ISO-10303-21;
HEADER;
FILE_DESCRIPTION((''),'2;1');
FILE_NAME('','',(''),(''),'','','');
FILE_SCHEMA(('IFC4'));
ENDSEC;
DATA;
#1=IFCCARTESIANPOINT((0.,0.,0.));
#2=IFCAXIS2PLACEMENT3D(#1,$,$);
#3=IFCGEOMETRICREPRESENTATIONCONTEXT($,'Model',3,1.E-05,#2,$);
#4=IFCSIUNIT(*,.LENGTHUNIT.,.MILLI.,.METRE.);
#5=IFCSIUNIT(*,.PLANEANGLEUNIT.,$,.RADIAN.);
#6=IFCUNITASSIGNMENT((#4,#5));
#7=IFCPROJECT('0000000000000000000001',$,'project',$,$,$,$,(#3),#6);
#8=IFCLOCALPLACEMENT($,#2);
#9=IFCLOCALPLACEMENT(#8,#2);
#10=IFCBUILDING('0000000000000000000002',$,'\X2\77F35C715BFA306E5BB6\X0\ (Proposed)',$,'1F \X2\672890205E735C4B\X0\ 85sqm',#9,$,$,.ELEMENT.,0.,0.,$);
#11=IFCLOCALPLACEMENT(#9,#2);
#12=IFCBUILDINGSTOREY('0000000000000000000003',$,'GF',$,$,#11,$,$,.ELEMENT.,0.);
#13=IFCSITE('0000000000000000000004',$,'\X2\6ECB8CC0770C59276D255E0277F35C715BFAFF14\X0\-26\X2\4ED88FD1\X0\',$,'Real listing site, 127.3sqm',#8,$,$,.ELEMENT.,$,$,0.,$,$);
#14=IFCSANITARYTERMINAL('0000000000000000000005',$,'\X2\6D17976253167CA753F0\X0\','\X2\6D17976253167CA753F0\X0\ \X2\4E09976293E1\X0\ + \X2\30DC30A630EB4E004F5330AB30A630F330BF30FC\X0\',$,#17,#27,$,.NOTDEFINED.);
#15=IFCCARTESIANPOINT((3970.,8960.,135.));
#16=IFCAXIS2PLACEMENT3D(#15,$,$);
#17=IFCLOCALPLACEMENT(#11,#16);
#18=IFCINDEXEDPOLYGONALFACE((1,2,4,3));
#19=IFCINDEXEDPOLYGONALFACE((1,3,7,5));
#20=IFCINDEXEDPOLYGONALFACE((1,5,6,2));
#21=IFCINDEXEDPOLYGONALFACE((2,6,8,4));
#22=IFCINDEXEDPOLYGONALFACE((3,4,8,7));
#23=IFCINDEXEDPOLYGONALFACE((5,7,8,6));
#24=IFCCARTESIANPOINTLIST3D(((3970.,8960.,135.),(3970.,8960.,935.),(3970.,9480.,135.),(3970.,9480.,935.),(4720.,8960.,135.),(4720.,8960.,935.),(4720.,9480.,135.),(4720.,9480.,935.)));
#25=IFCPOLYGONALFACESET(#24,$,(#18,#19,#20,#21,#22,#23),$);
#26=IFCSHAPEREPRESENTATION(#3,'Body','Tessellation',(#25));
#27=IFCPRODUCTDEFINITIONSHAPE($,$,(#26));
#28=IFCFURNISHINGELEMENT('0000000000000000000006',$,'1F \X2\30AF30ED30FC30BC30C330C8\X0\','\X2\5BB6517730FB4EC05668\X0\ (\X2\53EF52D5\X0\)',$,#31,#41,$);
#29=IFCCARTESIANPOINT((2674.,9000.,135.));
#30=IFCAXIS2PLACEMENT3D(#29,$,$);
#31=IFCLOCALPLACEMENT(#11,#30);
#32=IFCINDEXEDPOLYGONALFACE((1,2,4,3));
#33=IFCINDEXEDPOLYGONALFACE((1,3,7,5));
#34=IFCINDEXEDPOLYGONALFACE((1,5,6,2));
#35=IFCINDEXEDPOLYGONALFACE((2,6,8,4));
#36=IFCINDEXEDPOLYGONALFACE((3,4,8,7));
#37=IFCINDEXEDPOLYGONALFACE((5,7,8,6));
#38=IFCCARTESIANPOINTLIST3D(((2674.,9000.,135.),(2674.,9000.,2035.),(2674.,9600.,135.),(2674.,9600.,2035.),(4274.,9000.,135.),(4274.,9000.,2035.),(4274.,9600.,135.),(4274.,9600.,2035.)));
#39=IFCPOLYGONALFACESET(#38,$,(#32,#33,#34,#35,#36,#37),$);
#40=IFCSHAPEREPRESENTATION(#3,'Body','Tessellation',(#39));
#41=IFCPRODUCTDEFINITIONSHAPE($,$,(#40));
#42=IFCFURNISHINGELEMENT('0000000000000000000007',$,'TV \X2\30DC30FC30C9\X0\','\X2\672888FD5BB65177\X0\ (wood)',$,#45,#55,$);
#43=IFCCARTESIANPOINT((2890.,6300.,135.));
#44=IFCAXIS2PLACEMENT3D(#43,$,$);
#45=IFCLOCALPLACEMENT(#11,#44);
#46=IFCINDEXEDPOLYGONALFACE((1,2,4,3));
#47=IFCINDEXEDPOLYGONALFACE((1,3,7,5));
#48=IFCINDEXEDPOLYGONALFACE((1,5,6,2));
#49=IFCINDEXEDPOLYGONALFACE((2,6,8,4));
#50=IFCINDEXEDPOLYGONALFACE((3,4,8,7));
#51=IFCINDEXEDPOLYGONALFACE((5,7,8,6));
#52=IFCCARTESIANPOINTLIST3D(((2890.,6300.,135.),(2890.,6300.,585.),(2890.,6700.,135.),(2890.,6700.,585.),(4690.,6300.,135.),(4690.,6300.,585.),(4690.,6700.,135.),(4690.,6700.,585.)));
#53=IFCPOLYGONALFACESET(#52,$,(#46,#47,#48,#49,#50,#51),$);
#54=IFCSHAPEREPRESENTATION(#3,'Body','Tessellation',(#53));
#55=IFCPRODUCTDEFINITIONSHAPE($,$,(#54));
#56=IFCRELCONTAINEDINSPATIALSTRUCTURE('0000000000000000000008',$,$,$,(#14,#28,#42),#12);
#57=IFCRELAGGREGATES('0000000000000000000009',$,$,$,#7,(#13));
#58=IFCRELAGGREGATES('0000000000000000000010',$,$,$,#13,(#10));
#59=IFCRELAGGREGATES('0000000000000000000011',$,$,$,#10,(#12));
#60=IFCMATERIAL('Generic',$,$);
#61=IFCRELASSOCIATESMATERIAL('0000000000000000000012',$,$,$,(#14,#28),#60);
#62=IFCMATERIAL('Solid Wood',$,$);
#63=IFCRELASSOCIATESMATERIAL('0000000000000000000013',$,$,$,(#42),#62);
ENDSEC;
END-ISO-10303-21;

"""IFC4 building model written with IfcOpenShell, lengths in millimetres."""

from ifc_helpers import new_model, si_unit, frame, frame_2d, origin, place, context, project, spatial, rectangle, extrude, material, element, save


model = new_model("IFC4")

# Units and contexts
model_context = context("Model", 3, precision=1e-05, world=origin())
ifc_project = project(units=[si_unit("LENGTHUNIT", "METRE", prefix="MILLI"), si_unit("PLANEANGLEUNIT", "RADIAN")], contexts=[model_context])

# Site, building, storey
site_placement = place(None, origin())
site = spatial("IfcSite", under=ifc_project, at=site_placement, Name="滋賀県大津市石山寺４-26付近", ObjectType="Real listing site, 127.3sqm", CompositionType="ELEMENT", RefElevation=0.0)
building_placement = place(site_placement, origin())
building = spatial("IfcBuilding", under=site, at=building_placement, Name="石山寺の家 (Proposed)", ObjectType="1F 木造平屋 85sqm", CompositionType="ELEMENT", ElevationOfRefHeight=0.0, ElevationOfTerrain=0.0)
storey_placement = place(building_placement, origin())
storey = spatial("IfcBuildingStorey", under=building, at=storey_placement, Name="GF", CompositionType="ELEMENT", Elevation=0.0)

# Shared definitions
ifc_material_1 = material(Name="Solid Wood")

# Shared definitions
ifc_material_2 = material(Name="Generic")

# Sanitary terminal
sanitary_terminal_1_placement = place(storey_placement, frame((3970.0, 8960.0, 135.0)))
element("IfcSanitaryTerminal", 1, at=sanitary_terminal_1_placement, inside=storey, material=ifc_material_2, Name="洗面化粧台", Description="洗面化粧台 三面鏡 + ボウル一体カウンター", PredefinedType="NOTDEFINED", context=model_context, shape_type="SweptSolid", body=[
    extrude(rectangle(XDim=750.0, YDim=520.0, at=frame_2d((375.0, 260.0))), frame((3970.0, 8960.0, 135.0)), (0.0, 0.0, 1.0), 800.0),
])

# Furnishing elements
furnishing_1_placement = place(storey_placement, frame((2674.0, 9000.0, 135.0)))
element("IfcFurnishingElement", 2, at=furnishing_1_placement, inside=storey, material=ifc_material_2, Name="1F クローゼット", Description="家具・什器 (可動)", context=model_context, shape_type="SweptSolid", body=[
    extrude(rectangle(XDim=1600.0, YDim=600.0, at=frame_2d((800.0, 300.0))), frame((2674.0, 9000.0, 135.0)), (0.0, 0.0, 1.0), 1900.0),
])
furnishing_2_placement = place(storey_placement, frame((2890.0, 6300.0, 135.0)))
element("IfcFurnishingElement", 3, at=furnishing_2_placement, inside=storey, material=ifc_material_1, Name="TV ボード", Description="木製家具 (wood)", context=model_context, shape_type="SweptSolid", body=[
    extrude(rectangle(XDim=1800.0, YDim=400.0, at=frame_2d((900.0, 200.0))), frame((2890.0, 6300.0, 135.0)), (0.0, 0.0, 1.0), 450.0),
])

save(model, "model.ifc")
